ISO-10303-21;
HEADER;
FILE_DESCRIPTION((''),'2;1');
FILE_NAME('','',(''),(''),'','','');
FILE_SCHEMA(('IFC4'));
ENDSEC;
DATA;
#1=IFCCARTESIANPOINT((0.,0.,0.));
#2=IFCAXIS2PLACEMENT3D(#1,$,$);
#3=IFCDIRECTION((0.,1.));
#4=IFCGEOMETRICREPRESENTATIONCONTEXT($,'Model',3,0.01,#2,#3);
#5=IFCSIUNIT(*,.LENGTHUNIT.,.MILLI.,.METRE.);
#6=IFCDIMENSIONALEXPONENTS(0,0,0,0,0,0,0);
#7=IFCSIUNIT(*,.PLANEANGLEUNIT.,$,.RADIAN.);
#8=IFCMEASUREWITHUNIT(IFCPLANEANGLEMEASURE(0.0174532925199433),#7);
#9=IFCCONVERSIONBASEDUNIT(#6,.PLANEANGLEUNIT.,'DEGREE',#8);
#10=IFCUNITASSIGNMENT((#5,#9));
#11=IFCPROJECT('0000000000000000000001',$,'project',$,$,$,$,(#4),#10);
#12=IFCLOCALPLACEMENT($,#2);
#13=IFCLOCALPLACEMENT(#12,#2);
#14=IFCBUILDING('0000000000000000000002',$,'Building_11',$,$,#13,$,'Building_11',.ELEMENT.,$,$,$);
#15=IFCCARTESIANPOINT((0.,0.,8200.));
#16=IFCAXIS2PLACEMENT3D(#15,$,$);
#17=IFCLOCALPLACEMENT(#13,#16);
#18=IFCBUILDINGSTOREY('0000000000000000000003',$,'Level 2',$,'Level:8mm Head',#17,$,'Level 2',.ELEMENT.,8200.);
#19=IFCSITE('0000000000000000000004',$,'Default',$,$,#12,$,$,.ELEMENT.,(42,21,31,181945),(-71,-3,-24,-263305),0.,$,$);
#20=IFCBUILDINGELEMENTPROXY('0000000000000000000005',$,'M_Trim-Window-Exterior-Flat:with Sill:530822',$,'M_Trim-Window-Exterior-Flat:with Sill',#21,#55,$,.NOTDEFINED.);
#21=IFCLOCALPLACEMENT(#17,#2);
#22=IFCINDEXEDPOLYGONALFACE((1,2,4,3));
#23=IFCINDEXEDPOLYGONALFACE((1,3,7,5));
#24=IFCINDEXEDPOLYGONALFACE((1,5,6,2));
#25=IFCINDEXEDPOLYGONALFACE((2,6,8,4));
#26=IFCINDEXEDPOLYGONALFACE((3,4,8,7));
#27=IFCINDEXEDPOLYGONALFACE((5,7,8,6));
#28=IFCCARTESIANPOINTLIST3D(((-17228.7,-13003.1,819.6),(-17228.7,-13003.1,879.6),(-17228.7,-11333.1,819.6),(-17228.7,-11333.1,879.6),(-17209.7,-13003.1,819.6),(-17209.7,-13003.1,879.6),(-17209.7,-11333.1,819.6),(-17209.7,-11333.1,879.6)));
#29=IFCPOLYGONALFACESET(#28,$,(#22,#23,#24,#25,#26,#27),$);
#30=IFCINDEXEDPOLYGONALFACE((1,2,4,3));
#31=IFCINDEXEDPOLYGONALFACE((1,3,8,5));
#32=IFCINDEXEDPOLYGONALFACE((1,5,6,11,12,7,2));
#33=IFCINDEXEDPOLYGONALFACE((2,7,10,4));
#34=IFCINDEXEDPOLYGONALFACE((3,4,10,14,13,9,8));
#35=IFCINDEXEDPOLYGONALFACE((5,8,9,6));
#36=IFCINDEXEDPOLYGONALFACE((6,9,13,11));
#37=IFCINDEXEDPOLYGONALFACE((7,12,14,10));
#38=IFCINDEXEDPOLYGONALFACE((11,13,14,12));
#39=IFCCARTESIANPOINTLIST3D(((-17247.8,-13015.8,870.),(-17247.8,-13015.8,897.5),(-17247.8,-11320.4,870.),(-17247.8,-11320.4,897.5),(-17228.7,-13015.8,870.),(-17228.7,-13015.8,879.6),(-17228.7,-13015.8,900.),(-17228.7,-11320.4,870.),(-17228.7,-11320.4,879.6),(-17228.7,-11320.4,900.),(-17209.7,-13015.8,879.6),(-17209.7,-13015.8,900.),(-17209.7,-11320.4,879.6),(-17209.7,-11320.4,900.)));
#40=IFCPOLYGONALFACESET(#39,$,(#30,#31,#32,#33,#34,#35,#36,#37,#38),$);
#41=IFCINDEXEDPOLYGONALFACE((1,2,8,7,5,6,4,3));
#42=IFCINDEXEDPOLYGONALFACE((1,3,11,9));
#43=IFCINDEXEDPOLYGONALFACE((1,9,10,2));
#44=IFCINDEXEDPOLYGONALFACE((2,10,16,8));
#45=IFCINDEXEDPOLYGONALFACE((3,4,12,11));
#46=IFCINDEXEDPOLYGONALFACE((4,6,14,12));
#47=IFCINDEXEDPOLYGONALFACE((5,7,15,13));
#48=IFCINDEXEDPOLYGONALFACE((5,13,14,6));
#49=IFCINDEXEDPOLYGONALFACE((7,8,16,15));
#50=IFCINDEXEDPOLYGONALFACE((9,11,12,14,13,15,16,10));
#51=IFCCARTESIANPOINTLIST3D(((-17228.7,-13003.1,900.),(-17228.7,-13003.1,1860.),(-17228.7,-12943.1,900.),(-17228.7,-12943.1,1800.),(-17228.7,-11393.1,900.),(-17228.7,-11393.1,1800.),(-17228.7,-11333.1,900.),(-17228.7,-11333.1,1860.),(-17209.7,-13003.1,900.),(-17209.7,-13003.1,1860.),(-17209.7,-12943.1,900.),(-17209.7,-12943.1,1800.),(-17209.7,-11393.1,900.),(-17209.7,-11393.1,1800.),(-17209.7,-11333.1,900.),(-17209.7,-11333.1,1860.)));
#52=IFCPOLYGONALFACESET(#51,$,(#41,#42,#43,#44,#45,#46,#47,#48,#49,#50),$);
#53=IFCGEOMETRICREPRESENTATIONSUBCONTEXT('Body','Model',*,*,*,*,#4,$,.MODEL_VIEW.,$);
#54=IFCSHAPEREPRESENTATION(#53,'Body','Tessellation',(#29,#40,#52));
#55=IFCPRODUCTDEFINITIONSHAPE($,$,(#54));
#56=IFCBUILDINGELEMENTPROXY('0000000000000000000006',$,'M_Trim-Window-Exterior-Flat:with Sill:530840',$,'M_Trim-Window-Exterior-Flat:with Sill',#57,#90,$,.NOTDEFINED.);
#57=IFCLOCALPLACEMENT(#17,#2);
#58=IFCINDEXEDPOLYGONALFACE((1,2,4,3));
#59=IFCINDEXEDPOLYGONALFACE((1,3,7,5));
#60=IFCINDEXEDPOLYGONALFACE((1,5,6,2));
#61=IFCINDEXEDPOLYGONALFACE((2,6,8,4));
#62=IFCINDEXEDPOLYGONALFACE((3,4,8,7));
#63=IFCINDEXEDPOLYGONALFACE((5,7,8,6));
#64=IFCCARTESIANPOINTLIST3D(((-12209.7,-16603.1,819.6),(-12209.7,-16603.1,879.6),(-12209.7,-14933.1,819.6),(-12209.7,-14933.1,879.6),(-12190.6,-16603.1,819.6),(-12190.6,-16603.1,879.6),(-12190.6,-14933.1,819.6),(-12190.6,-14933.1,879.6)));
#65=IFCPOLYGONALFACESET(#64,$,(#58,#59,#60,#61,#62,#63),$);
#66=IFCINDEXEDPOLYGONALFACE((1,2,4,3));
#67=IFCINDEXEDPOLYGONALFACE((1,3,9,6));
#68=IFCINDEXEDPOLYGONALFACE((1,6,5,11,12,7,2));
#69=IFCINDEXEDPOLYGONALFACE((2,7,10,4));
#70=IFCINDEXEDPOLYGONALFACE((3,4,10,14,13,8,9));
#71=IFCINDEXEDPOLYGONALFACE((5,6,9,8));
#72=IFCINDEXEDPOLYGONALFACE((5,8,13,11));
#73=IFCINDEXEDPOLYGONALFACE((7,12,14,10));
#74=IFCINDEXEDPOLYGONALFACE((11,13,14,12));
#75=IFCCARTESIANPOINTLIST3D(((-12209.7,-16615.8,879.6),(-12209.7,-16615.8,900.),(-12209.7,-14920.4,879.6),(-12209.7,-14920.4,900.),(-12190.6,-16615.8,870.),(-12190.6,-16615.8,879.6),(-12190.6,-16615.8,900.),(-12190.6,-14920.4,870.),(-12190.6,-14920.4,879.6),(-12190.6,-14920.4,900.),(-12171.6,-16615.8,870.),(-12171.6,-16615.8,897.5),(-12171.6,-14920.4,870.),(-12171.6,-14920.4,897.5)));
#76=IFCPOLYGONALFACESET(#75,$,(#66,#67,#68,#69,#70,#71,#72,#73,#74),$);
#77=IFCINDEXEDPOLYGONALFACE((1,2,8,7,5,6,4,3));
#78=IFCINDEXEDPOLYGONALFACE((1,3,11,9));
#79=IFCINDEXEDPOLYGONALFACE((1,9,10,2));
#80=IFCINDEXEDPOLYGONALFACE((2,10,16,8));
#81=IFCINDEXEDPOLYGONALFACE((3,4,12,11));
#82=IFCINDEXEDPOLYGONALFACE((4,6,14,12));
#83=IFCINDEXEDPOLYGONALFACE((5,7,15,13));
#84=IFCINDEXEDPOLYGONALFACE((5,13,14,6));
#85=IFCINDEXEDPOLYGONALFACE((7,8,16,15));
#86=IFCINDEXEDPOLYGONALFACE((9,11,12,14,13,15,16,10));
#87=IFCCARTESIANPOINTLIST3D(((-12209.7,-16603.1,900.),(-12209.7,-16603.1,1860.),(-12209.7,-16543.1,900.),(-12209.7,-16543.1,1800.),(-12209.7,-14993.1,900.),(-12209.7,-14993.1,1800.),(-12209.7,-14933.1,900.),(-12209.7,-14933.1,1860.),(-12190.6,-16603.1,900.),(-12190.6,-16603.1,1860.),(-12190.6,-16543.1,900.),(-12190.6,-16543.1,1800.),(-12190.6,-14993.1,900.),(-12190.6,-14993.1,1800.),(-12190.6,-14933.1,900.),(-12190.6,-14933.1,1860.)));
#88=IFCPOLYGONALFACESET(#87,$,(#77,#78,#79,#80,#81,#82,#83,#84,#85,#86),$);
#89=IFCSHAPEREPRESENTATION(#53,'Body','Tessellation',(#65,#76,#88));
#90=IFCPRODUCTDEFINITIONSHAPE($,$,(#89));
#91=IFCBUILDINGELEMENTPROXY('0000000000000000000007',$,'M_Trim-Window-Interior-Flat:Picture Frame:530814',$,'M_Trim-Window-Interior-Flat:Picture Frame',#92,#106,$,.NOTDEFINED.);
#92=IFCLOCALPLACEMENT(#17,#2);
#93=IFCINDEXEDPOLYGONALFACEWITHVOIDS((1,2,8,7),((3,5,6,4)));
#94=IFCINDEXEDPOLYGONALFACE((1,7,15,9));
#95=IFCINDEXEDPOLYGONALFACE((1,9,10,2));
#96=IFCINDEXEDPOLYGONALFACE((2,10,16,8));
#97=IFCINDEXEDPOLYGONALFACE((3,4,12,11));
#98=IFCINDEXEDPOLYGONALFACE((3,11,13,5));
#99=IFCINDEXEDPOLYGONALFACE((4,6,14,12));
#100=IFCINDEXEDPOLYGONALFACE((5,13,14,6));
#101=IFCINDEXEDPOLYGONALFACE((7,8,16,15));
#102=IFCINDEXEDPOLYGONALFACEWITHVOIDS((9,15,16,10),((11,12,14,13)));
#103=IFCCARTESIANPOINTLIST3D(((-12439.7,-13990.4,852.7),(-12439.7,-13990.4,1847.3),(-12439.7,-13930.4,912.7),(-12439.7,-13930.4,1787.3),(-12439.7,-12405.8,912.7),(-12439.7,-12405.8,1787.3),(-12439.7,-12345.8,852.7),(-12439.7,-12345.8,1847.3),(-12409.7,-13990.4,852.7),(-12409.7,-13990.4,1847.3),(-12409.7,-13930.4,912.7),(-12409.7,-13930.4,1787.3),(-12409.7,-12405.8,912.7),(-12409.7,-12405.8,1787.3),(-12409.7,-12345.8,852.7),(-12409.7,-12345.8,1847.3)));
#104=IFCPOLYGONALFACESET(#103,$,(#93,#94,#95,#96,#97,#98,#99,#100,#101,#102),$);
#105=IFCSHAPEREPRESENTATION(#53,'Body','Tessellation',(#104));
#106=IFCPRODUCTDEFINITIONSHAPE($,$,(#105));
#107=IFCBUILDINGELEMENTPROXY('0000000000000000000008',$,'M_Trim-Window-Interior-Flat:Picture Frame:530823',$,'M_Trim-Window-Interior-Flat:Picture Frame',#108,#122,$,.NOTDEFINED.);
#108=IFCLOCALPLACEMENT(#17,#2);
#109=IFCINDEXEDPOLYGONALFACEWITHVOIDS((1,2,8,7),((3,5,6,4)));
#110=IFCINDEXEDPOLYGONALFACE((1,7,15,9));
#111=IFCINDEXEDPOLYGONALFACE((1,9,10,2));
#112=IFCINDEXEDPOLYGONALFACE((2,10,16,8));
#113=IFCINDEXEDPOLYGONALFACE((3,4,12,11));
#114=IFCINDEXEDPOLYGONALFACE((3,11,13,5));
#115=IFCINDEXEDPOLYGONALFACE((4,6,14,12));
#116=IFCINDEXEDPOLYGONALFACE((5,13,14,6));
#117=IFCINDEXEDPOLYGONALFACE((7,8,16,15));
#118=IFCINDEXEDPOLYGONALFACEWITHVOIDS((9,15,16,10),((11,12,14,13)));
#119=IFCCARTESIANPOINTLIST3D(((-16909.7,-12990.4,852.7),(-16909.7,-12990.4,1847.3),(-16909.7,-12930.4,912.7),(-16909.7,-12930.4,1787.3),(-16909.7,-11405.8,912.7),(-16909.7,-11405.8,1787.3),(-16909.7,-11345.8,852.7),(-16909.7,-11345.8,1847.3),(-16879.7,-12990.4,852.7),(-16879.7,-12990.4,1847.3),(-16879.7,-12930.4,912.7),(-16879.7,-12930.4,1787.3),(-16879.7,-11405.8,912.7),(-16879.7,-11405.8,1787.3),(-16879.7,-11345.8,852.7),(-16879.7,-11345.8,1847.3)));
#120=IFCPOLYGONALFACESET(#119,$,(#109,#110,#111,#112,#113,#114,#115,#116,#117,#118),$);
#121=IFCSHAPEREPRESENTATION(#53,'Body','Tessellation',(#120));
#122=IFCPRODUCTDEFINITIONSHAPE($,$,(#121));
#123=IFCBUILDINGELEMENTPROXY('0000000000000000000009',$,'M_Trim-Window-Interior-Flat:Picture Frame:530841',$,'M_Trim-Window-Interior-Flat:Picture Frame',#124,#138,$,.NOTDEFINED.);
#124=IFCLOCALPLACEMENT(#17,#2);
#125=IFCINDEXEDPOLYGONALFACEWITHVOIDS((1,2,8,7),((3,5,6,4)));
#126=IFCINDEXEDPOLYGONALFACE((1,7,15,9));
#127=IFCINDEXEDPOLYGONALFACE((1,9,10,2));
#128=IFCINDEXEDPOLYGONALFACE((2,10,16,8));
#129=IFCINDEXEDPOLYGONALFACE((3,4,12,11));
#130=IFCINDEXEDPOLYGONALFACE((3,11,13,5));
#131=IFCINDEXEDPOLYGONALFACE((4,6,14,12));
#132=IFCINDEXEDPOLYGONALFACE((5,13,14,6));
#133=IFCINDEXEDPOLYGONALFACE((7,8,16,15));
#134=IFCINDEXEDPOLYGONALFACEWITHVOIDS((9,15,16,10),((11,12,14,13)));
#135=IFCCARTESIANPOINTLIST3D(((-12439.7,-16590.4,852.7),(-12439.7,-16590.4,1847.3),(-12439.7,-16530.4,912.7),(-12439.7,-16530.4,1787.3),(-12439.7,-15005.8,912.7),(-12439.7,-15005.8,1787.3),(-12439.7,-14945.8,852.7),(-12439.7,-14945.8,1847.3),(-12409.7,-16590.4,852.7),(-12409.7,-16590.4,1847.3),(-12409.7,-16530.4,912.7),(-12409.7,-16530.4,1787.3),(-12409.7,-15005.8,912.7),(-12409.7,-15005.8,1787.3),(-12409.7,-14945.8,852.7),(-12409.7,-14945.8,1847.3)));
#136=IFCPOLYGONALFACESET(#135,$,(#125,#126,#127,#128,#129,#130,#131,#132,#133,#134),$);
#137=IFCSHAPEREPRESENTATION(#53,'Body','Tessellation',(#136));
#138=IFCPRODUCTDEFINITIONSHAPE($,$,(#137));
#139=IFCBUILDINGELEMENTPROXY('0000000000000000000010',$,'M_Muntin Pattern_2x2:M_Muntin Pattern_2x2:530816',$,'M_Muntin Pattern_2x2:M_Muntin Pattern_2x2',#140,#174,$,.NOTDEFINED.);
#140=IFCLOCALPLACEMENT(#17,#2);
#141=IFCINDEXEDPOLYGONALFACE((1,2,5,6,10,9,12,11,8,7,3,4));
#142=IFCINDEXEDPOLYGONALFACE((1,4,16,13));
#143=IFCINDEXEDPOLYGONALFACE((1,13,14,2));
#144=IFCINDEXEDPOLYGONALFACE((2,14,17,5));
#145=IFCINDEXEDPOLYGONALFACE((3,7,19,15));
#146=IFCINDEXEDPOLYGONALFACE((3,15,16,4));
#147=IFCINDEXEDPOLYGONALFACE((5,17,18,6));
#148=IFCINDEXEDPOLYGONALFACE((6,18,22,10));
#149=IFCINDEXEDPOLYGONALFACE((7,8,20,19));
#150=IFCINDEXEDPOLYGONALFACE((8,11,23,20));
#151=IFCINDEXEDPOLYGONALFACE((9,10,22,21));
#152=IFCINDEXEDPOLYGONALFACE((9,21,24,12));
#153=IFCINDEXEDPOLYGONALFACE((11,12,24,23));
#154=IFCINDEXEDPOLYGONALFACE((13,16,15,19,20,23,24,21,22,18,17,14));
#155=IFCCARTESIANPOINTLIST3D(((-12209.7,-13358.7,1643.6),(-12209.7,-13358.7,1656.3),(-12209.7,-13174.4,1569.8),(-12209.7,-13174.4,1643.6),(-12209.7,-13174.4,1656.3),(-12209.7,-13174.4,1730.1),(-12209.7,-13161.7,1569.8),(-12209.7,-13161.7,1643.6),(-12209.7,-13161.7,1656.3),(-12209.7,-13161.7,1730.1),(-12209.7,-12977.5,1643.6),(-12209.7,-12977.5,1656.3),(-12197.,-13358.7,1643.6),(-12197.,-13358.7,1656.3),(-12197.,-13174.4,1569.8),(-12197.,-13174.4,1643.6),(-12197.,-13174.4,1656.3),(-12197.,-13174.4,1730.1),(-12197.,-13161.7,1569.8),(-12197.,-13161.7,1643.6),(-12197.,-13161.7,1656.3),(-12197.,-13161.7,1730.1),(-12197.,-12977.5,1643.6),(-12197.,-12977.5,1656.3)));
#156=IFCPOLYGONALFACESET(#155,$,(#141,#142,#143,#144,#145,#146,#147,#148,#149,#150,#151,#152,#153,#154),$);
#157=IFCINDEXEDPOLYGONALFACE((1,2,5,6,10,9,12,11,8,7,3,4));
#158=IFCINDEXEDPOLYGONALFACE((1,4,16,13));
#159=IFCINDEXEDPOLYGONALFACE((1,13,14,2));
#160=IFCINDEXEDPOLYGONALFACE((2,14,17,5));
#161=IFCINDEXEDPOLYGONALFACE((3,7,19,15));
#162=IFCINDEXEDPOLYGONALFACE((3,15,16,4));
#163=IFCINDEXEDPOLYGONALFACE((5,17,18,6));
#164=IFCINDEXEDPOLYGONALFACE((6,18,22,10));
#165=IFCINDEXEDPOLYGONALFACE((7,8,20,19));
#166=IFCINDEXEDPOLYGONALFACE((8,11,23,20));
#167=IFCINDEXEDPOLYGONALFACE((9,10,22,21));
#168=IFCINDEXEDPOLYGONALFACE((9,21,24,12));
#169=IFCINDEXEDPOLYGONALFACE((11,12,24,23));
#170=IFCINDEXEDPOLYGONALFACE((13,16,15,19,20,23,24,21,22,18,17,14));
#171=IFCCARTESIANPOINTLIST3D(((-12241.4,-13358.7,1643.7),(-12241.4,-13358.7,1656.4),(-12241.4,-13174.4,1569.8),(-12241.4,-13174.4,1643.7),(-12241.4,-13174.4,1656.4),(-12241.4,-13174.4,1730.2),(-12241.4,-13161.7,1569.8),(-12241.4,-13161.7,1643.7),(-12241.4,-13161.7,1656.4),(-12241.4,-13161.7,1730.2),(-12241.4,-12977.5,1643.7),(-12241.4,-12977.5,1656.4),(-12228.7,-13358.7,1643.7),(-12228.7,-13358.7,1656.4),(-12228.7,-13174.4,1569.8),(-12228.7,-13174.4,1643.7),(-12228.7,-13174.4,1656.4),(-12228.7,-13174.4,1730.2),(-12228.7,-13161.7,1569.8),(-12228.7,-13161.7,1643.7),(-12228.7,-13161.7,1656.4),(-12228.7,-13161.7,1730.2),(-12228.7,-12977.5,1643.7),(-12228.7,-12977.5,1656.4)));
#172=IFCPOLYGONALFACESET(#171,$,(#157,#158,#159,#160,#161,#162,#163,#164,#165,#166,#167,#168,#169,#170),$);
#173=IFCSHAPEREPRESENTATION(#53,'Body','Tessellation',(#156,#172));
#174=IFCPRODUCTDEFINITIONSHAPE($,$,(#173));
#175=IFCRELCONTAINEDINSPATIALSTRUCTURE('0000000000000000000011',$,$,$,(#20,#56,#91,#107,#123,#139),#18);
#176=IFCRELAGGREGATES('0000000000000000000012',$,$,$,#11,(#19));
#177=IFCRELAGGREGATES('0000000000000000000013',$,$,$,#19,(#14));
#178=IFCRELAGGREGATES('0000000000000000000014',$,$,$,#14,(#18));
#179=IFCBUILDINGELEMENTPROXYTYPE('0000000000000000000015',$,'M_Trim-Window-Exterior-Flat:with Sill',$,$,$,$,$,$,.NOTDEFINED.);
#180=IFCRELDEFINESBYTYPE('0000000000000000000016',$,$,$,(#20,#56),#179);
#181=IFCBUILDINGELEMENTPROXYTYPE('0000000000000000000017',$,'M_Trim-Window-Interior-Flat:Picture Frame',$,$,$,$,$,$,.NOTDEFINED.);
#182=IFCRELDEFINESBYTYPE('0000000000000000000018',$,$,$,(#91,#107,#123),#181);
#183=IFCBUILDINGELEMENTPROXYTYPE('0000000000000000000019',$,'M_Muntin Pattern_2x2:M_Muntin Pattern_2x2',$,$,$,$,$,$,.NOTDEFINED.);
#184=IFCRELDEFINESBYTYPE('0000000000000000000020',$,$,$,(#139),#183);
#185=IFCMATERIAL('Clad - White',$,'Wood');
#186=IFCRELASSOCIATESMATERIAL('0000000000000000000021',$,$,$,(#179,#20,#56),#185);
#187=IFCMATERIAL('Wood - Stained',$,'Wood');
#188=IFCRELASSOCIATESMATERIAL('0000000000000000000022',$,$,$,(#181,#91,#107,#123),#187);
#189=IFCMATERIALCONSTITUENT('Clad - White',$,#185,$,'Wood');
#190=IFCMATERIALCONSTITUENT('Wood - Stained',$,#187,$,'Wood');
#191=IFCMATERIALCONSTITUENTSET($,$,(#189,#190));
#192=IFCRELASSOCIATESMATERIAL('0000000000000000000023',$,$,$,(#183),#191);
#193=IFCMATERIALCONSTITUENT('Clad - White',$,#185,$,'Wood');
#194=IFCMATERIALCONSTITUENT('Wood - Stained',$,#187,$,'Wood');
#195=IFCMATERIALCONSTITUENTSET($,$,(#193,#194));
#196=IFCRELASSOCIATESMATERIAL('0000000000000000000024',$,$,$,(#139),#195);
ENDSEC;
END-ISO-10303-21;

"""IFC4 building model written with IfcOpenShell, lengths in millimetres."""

from ifc_helpers import new_model, entity, si_unit, converted_unit, direction, frame, origin, place, context, subcontext, project, spatial, indexed_curve, outline, extrude, source, transform, mapped, material, constituent, constituent_set, type_object, type_shapes, element, save


model = new_model("IFC4")

# Units and contexts
model_context = context("Model", 3, precision=0.01, world=origin(), true_north=direction((0.0, 1.0)))
body_context = subcontext(model_context, "Body", "Model", "MODEL_VIEW")
ifc_project = project(units=[si_unit("LENGTHUNIT", "METRE", prefix="MILLI"), converted_unit("PLANEANGLEUNIT", "DEGREE", entity("IfcPlaneAngleMeasure", 0.0174532925199433), si_unit("PLANEANGLEUNIT", "RADIAN"), dimensions=[0, 0, 0, 0, 0, 0, 0])], contexts=[model_context])

# Site, building, storey
site_placement = place(None, origin())
site = spatial("IfcSite", under=ifc_project, at=site_placement, Name="Default", CompositionType="ELEMENT", RefLatitude=(42, 21, 31, 181945), RefLongitude=(-71, -3, -24, -263305), RefElevation=0.0)
building_placement = place(site_placement, origin())
building = spatial("IfcBuilding", under=site, at=building_placement, Name="Building_11", LongName="Building_11", CompositionType="ELEMENT")
storey_placement = place(building_placement, frame((0.0, 0.0, 8200.0)))
storey = spatial("IfcBuildingStorey", under=building, at=storey_placement, Name="Level 2", ObjectType="Level:8mm Head", LongName="Level 2", CompositionType="ELEMENT", Elevation=8200.0)

# Building element proxies
ifc_material_1 = material(Name="Clad - White", Category="Wood")
ifc_material_2 = material(Name="Wood - Stained", Category="Wood")
building_element_proxy_type_1 = type_object("IfcBuildingElementProxyType", Name="M_Trim-Window-Exterior-Flat:with Sill", PredefinedType="NOTDEFINED", material=ifc_material_1)
shared_shape_1 = source(origin(), body_context, "Body", "SweptSolid", [
    extrude(outline(indexed_curve([(-835.0, -30.0), (835.0, -30.0), (835.0, 30.0), (-835.0, 30.0), (-835.0, -30.0)], self_intersect=False)), frame((0.0, -950.4, 0.0), z_axis=(0.0, 0.0, 1.0), x_axis=(-1.0, 0.0, 0.0)), (0.0, 0.0, 1.0), 19.1),
    extrude(outline(indexed_curve([(-19.0, -15.2), (0.0, -15.2), (0.0, -5.7), (19.0, -5.7), (19.0, 14.8), (0.0, 14.8), (-19.0, 12.3), (-19.0, -15.2)], self_intersect=False)), frame((-847.7, -914.8, 19.0), z_axis=(1.0, 0.0, 0.0), x_axis=(0.0, 0.0, -1.0)), (0.0, 0.0, 1.0), 1695.4),
    extrude(outline(indexed_curve([(-495.0, -835.0), (465.0, -835.0), (465.0, -775.0), (-435.0, -775.0), (-435.0, 775.0), (465.0, 775.0), (465.0, 835.0), (-495.0, 835.0), (-495.0, -835.0)], self_intersect=False)), frame((0.0, -435.0, 0.0), z_axis=(0.0, 0.0, 1.0), x_axis=(0.0, -1.0, 0.0)), (0.0, 0.0, 1.0), 19.1),
])
type_shapes(building_element_proxy_type_1, [shared_shape_1])
for number, where, z_axis, x_axis, name in (
    (1, (-17209.7, -12168.1, 1800.0), (-1.0, 0.0, 0.0), (0.0, -1.0, 0.0), "M_Trim-Window-Exterior-Flat:with Sill:530822"),
    (2, (-12209.7, -15768.1, 1800.0), (1.0, 0.0, 0.0), (0.0, 1.0, 0.0), "M_Trim-Window-Exterior-Flat:with Sill:530840"),
):
    element("IfcBuildingElementProxy", number, at=place(storey_placement, frame(where, z_axis=z_axis, x_axis=x_axis)), inside=storey, type_object=building_element_proxy_type_1, material=ifc_material_1, Name=name, ObjectType="M_Trim-Window-Exterior-Flat:with Sill", PredefinedType="NOTDEFINED", context=body_context, shape_type="MappedRepresentation", body=[
        mapped(shared_shape_1, transform((0.0, 0.0, 0.0), scale=1.0)),
    ])
building_element_proxy_type_2 = type_object("IfcBuildingElementProxyType", Name="M_Trim-Window-Interior-Flat:Picture Frame", PredefinedType="NOTDEFINED", material=ifc_material_2)
shared_shape_2 = source(origin(), body_context, "Body", "SweptSolid", [
    extrude(outline(indexed_curve([(-822.3, -497.3), (822.3, -497.3), (822.3, 497.3), (-822.3, 497.3), (-822.3, -497.3)], self_intersect=False), holes=[indexed_curve([(-762.3, -437.3), (-762.3, 437.3), (762.3, 437.3), (762.3, -437.3), (-762.3, -437.3)], self_intersect=False)]), frame((0.0, -450.0, 0.0), z_axis=(0.0, 0.0, 1.0), x_axis=(-1.0, 0.0, 0.0)), (0.0, 0.0, 1.0), 30.0),
])
type_shapes(building_element_proxy_type_2, [shared_shape_2])
for number, where, z_axis, x_axis, name in (
    (3, (-12409.7, -13168.1, 1800.0), (-1.0, 0.0, 0.0), (0.0, -1.0, 0.0), "M_Trim-Window-Interior-Flat:Picture Frame:530814"),
    (4, (-16909.7, -12168.1, 1800.0), (1.0, 0.0, 0.0), (0.0, 1.0, 0.0), "M_Trim-Window-Interior-Flat:Picture Frame:530823"),
    (5, (-12409.7, -15768.1, 1800.0), (-1.0, 0.0, 0.0), (0.0, -1.0, 0.0), "M_Trim-Window-Interior-Flat:Picture Frame:530841"),
):
    element("IfcBuildingElementProxy", number, at=place(storey_placement, frame(where, z_axis=z_axis, x_axis=x_axis)), inside=storey, type_object=building_element_proxy_type_2, material=ifc_material_2, Name=name, ObjectType="M_Trim-Window-Interior-Flat:Picture Frame", PredefinedType="NOTDEFINED", context=body_context, shape_type="MappedRepresentation", body=[
        mapped(shared_shape_2, transform((0.0, 0.0, 0.0), scale=1.0)),
    ])
ifc_constituent_1 = constituent(ifc_material_1, Name="Clad - White", Category="Wood")
ifc_constituent_2 = constituent(ifc_material_2, Name="Wood - Stained", Category="Wood")
ifc_constituent_set_1 = constituent_set(constituents=[ifc_constituent_1, ifc_constituent_2])
ifc_constituent_3 = constituent(ifc_material_1, Name="Clad - White", Category="Wood")
ifc_constituent_4 = constituent(ifc_material_2, Name="Wood - Stained", Category="Wood")
ifc_constituent_set_2 = constituent_set(constituents=[ifc_constituent_3, ifc_constituent_4])
building_element_proxy_type_3 = type_object("IfcBuildingElementProxyType", Name="M_Muntin Pattern_2x2:M_Muntin Pattern_2x2", PredefinedType="NOTDEFINED", material=ifc_constituent_set_2)
shared_shape_3 = source(origin(), body_context, "Body", "SweptSolid", [
    extrude(outline(indexed_curve([(6.4, -6.4), (80.1, -6.4), (80.1, 6.3), (6.4, 6.3), (6.4, 190.6), (-6.3, 190.6), (-6.3, 6.3), (-80.2, 6.3), (-80.2, -6.4), (-6.3, -6.4), (-6.3, -190.6), (6.4, -190.6), (6.4, -6.4)], self_intersect=False)), frame((0.0, 9.5, 80.1), z_axis=(0.0, 1.0, 0.0), x_axis=(0.0, 0.0, 1.0)), (0.0, 0.0, 1.0), 12.7),
    extrude(outline(indexed_curve([(6.4, -6.4), (80.2, -6.4), (80.2, 6.3), (6.4, 6.3), (6.4, 190.6), (-6.3, 190.6), (-6.3, 6.3), (-80.2, 6.3), (-80.2, -6.4), (-6.3, -6.4), (-6.3, -190.6), (6.4, -190.6), (6.4, -6.4)], self_intersect=False)), frame((0.0, -22.2, 80.2), z_axis=(0.0, 1.0, 0.0), x_axis=(0.0, 0.0, 1.0)), (0.0, 0.0, 1.0), 12.7),
])
type_shapes(building_element_proxy_type_3, [shared_shape_3])
proxy_1_placement = place(storey_placement, frame((-12219.2, -13168.1, 1569.8), z_axis=(0.0, 0.0, 1.0), x_axis=(0.0, -1.0, 0.0)))
element("IfcBuildingElementProxy", 6, at=proxy_1_placement, inside=storey, type_object=building_element_proxy_type_3, material=ifc_constituent_set_1, Name="M_Muntin Pattern_2x2:M_Muntin Pattern_2x2:530816", ObjectType="M_Muntin Pattern_2x2:M_Muntin Pattern_2x2", PredefinedType="NOTDEFINED", context=body_context, shape_type="MappedRepresentation", body=[
    mapped(shared_shape_3, transform((0.0, 0.0, 0.0), scale=1.0)),
])

save(model, "model.ifc")
